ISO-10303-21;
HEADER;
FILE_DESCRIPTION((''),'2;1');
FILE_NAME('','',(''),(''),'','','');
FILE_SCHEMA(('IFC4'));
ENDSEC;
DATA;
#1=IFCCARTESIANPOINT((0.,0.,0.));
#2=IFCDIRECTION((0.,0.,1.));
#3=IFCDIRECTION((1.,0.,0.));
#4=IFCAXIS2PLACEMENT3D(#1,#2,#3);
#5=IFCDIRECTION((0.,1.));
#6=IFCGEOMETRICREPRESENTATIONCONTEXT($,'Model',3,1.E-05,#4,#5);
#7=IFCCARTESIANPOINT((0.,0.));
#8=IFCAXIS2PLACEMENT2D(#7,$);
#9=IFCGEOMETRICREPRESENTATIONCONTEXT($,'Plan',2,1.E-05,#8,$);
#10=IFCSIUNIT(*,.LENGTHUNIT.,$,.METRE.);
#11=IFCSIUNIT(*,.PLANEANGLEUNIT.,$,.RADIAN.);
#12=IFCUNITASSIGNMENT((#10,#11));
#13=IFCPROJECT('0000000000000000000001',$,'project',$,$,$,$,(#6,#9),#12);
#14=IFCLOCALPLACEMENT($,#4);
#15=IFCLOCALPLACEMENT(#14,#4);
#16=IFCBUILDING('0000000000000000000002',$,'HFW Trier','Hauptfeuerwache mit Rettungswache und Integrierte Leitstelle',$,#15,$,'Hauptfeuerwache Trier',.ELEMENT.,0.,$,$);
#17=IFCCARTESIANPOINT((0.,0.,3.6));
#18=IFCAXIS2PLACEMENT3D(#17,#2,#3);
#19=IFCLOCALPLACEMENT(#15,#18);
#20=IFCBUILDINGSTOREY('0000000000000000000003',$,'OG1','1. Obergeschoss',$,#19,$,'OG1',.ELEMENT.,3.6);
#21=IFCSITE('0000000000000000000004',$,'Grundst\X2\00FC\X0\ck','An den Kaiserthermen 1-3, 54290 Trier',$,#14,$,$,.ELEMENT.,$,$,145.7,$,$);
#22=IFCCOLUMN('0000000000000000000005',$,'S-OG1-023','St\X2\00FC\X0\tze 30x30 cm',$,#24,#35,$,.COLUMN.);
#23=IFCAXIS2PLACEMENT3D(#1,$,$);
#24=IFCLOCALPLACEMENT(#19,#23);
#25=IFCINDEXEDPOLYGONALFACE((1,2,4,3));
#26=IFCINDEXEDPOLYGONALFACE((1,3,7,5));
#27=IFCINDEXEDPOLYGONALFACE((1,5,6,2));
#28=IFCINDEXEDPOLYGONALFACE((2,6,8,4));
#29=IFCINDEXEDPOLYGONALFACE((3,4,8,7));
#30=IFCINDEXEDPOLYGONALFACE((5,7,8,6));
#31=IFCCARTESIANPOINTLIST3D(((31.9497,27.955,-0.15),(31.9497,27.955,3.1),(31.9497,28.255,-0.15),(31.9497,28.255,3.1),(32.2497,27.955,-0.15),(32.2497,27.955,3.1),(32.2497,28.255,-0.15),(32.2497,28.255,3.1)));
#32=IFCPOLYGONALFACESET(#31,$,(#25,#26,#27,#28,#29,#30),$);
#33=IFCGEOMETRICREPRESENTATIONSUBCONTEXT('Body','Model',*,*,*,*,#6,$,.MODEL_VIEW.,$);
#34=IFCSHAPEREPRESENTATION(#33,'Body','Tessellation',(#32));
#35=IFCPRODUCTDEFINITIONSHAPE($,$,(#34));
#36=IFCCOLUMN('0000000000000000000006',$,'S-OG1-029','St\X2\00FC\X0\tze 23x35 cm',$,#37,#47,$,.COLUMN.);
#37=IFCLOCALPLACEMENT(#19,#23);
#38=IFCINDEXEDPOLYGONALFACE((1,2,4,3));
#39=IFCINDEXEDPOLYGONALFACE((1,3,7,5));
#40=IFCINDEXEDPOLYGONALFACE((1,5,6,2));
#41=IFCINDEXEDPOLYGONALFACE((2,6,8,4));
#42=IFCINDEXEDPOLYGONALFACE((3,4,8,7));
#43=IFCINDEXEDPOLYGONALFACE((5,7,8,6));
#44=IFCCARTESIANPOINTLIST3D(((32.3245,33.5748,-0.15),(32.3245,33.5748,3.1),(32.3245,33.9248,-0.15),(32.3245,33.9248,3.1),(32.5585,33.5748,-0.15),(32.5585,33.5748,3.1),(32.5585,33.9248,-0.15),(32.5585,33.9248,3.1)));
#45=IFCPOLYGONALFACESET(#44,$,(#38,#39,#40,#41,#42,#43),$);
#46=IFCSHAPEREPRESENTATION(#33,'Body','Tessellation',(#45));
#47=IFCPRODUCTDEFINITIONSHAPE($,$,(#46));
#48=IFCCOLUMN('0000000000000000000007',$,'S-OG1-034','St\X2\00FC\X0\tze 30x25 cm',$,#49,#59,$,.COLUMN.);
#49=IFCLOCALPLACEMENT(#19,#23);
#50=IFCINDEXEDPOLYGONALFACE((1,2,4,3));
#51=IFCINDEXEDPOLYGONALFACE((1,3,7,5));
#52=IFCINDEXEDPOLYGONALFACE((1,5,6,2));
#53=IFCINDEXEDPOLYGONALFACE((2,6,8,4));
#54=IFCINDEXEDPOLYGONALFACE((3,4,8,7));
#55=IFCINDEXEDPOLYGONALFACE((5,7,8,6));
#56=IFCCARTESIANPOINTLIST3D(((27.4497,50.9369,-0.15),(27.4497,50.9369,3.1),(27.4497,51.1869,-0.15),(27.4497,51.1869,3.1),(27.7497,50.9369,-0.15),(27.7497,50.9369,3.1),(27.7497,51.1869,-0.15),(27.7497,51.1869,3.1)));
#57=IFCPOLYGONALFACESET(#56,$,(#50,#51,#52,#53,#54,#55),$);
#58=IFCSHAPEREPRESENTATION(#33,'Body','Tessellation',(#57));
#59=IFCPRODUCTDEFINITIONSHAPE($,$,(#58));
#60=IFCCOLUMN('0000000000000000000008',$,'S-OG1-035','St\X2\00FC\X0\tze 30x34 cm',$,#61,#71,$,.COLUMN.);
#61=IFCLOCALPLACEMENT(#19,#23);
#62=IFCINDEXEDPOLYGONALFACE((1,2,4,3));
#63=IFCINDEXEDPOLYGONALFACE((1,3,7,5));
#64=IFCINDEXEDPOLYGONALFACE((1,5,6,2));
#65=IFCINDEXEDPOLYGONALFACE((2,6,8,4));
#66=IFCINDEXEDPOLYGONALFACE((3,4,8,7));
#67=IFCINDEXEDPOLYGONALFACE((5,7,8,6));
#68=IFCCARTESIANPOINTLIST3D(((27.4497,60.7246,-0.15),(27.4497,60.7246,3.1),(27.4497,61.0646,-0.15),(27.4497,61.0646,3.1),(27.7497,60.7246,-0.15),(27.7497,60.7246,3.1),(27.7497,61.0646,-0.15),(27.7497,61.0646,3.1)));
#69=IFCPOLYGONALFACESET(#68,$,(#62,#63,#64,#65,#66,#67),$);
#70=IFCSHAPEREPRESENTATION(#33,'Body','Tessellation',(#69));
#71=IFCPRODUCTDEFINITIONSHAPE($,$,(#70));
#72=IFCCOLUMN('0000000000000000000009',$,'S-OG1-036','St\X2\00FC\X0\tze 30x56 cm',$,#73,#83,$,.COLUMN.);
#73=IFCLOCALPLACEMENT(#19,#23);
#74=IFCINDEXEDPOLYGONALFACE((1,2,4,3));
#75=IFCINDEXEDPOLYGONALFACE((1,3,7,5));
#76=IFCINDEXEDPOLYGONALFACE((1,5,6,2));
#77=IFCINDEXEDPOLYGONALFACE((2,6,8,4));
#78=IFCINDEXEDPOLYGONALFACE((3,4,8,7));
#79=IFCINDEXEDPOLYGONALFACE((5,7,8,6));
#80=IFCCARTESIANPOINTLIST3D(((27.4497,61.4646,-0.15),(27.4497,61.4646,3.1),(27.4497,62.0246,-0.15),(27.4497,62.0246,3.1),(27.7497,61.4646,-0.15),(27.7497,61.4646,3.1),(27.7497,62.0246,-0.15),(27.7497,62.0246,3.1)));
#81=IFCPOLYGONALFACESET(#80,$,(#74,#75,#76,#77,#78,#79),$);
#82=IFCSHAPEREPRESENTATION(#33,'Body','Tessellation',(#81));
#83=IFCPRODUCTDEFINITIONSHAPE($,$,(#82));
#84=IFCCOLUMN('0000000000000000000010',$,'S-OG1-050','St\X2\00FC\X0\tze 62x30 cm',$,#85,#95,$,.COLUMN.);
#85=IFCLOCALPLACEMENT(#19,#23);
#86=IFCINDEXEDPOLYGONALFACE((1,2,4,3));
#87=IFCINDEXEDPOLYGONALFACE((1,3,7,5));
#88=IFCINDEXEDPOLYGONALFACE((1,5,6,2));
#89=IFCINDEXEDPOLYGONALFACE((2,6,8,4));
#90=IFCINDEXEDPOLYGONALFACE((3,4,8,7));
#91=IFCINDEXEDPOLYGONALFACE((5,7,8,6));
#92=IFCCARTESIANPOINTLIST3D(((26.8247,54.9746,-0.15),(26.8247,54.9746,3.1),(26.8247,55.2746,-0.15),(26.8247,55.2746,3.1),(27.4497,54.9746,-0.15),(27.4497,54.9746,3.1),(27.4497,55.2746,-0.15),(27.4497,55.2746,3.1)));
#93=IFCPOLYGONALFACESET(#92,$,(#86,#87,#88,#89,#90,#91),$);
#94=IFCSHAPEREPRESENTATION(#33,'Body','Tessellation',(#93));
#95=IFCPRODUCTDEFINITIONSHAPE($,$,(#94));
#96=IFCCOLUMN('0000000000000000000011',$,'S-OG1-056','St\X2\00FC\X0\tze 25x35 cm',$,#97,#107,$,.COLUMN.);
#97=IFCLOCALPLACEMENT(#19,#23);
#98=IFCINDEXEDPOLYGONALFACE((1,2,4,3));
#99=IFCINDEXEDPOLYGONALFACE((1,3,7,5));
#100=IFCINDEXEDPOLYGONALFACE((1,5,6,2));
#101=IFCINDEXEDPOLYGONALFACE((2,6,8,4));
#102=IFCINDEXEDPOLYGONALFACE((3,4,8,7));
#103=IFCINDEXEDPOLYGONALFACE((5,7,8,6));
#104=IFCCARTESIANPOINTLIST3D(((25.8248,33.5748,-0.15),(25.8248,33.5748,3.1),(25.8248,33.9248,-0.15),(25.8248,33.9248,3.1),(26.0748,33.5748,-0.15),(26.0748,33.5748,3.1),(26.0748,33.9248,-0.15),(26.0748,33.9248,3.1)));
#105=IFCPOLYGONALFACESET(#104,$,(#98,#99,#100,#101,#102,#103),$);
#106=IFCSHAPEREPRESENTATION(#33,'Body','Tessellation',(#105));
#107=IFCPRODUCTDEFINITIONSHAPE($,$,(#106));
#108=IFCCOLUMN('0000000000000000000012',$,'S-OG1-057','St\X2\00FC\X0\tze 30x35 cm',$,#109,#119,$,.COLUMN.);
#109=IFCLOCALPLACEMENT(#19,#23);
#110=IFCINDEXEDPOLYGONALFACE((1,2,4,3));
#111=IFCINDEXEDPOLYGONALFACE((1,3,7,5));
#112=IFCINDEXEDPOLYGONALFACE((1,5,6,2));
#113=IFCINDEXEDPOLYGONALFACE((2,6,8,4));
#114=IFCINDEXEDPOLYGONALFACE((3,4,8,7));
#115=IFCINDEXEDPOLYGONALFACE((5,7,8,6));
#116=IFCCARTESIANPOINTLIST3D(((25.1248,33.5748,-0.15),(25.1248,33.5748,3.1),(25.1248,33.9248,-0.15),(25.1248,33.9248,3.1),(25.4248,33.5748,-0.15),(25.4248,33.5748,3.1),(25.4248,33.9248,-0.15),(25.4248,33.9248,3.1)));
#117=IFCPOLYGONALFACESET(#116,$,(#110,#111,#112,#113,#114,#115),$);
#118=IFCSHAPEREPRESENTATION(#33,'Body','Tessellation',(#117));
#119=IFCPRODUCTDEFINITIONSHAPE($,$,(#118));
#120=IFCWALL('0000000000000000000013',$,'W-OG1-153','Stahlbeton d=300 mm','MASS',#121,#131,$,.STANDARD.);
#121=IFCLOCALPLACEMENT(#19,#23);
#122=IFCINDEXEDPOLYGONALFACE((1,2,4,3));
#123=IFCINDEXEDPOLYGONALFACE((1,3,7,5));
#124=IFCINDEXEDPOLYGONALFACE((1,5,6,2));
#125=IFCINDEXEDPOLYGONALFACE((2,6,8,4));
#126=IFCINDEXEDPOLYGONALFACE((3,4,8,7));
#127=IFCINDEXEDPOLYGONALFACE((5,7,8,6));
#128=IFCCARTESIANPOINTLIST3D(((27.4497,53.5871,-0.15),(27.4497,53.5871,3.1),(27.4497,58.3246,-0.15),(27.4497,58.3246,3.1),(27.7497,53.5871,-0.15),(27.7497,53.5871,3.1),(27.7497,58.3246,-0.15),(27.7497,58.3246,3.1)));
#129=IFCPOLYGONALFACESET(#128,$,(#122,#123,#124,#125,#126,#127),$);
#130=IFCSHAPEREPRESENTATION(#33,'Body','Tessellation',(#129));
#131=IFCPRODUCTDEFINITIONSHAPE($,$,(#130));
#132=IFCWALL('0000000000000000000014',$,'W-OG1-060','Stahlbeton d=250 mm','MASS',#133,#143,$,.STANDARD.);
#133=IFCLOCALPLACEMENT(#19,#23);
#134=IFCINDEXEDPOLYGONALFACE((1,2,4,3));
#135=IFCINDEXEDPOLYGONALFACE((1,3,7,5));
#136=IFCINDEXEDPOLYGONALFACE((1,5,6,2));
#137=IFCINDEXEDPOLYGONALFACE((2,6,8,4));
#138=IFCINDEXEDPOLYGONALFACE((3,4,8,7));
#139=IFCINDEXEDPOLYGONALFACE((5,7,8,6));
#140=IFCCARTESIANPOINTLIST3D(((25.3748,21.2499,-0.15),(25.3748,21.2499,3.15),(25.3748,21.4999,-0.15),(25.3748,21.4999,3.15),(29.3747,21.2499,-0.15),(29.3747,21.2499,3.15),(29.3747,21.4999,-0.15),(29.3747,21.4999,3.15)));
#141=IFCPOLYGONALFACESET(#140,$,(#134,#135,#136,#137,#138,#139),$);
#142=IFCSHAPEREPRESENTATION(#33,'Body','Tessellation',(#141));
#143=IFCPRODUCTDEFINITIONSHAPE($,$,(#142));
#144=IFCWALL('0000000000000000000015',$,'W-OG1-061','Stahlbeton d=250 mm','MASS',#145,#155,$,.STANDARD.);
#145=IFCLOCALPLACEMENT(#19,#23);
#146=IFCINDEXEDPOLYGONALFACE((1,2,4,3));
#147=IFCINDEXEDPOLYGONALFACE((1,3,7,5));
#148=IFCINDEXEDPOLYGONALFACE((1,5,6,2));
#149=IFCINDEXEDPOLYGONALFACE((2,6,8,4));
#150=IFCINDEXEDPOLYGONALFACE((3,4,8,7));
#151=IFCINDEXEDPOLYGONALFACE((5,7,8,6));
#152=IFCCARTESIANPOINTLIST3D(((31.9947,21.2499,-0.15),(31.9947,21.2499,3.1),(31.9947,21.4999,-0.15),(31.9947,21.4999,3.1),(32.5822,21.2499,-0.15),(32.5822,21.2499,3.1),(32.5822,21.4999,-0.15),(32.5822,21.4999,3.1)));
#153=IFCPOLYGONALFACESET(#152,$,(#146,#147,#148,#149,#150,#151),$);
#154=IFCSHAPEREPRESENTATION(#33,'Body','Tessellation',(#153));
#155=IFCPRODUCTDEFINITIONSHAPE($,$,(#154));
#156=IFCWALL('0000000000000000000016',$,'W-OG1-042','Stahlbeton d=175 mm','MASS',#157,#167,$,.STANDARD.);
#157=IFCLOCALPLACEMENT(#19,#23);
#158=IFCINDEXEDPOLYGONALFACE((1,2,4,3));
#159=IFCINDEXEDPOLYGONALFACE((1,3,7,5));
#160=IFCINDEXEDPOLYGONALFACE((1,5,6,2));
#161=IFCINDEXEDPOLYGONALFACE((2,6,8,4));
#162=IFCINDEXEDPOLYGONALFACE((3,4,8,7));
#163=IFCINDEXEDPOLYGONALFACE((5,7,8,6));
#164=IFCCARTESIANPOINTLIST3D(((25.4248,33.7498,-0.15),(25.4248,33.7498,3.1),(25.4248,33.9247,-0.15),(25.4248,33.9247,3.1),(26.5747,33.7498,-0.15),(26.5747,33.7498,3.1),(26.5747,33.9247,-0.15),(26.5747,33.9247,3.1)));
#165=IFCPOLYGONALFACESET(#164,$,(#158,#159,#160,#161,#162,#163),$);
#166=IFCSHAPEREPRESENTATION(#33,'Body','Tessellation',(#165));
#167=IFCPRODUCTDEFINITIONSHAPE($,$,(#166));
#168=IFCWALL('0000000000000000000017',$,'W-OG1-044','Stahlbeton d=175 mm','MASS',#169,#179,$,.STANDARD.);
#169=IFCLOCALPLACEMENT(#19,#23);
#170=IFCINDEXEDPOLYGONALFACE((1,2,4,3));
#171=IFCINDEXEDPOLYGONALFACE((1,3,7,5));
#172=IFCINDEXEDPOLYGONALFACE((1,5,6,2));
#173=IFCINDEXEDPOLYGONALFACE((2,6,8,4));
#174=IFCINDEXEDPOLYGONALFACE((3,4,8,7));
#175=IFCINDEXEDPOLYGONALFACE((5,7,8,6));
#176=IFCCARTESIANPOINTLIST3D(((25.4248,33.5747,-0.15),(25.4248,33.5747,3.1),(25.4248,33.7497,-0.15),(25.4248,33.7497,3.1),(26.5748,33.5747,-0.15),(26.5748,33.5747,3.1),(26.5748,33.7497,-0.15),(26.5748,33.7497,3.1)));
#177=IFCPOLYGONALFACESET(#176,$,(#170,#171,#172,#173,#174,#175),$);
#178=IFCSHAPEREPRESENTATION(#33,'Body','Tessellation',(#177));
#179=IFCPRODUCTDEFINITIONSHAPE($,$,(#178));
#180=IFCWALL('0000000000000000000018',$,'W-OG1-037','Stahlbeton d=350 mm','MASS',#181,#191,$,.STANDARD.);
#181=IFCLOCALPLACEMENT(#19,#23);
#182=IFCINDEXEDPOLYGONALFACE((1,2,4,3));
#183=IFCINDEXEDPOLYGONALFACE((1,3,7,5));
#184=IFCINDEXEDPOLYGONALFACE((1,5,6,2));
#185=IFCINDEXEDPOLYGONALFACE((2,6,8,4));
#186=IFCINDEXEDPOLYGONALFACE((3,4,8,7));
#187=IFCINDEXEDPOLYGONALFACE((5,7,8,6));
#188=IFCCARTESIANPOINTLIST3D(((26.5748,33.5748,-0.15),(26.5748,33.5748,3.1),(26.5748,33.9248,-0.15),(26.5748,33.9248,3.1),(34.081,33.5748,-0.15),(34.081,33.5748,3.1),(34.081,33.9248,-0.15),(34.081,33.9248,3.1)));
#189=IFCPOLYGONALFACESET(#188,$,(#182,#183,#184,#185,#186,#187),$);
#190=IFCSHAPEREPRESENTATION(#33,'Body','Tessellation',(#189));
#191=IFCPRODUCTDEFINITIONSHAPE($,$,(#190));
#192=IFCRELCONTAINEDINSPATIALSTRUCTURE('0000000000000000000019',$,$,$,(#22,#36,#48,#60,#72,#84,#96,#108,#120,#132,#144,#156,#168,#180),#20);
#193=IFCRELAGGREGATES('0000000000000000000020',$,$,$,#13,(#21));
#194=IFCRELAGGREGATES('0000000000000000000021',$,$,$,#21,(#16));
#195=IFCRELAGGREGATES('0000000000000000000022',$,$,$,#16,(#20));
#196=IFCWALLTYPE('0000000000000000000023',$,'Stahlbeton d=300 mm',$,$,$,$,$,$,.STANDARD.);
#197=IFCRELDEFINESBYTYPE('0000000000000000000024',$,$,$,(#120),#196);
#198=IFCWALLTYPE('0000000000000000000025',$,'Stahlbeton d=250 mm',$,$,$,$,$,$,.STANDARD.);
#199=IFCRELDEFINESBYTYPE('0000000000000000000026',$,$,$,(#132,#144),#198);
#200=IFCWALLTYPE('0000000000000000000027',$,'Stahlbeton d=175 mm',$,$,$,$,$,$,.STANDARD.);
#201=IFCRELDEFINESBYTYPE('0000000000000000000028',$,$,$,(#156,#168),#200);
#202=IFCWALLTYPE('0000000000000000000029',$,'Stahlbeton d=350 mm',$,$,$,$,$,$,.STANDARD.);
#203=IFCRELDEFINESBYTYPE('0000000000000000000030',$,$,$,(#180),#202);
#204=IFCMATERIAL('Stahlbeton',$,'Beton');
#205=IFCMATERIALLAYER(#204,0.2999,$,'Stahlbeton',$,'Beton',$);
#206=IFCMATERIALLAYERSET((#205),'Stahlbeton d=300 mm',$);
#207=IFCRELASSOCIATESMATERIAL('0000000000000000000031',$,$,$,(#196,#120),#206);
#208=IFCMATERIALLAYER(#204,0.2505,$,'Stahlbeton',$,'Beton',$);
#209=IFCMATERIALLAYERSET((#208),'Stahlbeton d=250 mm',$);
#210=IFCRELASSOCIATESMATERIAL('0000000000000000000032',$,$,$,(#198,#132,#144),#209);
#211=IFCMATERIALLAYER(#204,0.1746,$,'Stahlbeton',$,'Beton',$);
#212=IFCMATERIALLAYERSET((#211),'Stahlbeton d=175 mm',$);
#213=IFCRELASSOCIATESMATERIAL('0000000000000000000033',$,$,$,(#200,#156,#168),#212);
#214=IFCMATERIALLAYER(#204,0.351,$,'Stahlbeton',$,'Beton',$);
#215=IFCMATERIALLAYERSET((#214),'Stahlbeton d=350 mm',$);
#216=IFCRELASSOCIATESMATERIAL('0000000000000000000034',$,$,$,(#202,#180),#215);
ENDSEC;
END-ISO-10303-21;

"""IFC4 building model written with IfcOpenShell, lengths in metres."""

from ifc_helpers import new_model, si_unit, direction, frame, frame_2d, origin_with_axes, origin_2d, place, context, subcontext, project, spatial, rectangle, extrude, material, layer, layer_set, layer_usage, type_object, element, save


model = new_model("IFC4")

# Units and contexts
model_context = context("Model", 3, precision=1e-05, world=origin_with_axes(), true_north=direction((0.0, 1.0)))
plan_context = context("Plan", 2, precision=1e-05, world=origin_2d())
body_context = subcontext(model_context, "Body", "Model", "MODEL_VIEW")
ifc_project = project(units=[si_unit("LENGTHUNIT", "METRE"), si_unit("PLANEANGLEUNIT", "RADIAN")], contexts=[model_context, plan_context])

# Site, building, storey
site_placement = place(None, origin_with_axes())
site = spatial("IfcSite", under=ifc_project, at=site_placement, Name="Grundstück", Description="An den Kaiserthermen 1-3, 54290 Trier", CompositionType="ELEMENT", RefElevation=145.7)
building_placement = place(site_placement, origin_with_axes())
building = spatial("IfcBuilding", under=site, at=building_placement, Name="HFW Trier", Description="Hauptfeuerwache mit Rettungswache und Integrierte Leitstelle", LongName="Hauptfeuerwache Trier", CompositionType="ELEMENT", ElevationOfRefHeight=0.0)
storey_placement = place(building_placement, frame((0.0, 0.0, 3.6), z_axis=(0.0, 0.0, 1.0), x_axis=(1.0, 0.0, 0.0)))
storey = spatial("IfcBuildingStorey", under=building, at=storey_placement, Name="OG1", Description="1. Obergeschoss", LongName="OG1", CompositionType="ELEMENT", Elevation=3.6)

# Columns
column_1_placement = place(storey_placement, frame((31.9497, 28.105, -0.15), z_axis=(0.0, 0.0, 1.0), x_axis=(1.0, 0.0, 0.0)))
element("IfcColumn", 1, at=column_1_placement, inside=storey, Name="S-OG1-023", Description="Stütze 30x30 cm", PredefinedType="COLUMN", context=body_context, shape_type="SweptSolid", body=[
    extrude(rectangle(XDim=0.3, YDim=0.3, at=frame_2d((0.15, 0.0))), origin_with_axes(), (0.0, 0.0, 1.0), 3.25),
])
column_2_placement = place(storey_placement, frame((32.3245, 33.7498, -0.15), z_axis=(0.0, 0.0, 1.0), x_axis=(1.0, 0.0, 0.0)))
element("IfcColumn", 2, at=column_2_placement, inside=storey, Name="S-OG1-029", Description="Stütze 23x35 cm", PredefinedType="COLUMN", context=body_context, shape_type="SweptSolid", body=[
    extrude(rectangle(XDim=0.234, YDim=0.35, at=frame_2d((0.117, 0.0))), origin_with_axes(), (0.0, 0.0, 1.0), 3.25),
])
column_3_placement = place(storey_placement, frame((27.4497, 51.0619, -0.15), z_axis=(0.0, 0.0, 1.0), x_axis=(1.0, 0.0, 0.0)))
element("IfcColumn", 3, at=column_3_placement, inside=storey, Name="S-OG1-034", Description="Stütze 30x25 cm", PredefinedType="COLUMN", context=body_context, shape_type="SweptSolid", body=[
    extrude(rectangle(XDim=0.3, YDim=0.25, at=frame_2d((0.15, 0.0))), origin_with_axes(), (0.0, 0.0, 1.0), 3.25),
])
column_4_placement = place(storey_placement, frame((27.4497, 60.8946, -0.15), z_axis=(0.0, 0.0, 1.0), x_axis=(1.0, 0.0, 0.0)))
element("IfcColumn", 4, at=column_4_placement, inside=storey, Name="S-OG1-035", Description="Stütze 30x34 cm", PredefinedType="COLUMN", context=body_context, shape_type="SweptSolid", body=[
    extrude(rectangle(XDim=0.3, YDim=0.34, at=frame_2d((0.15, 0.0))), origin_with_axes(), (0.0, 0.0, 1.0), 3.25),
])
column_5_placement = place(storey_placement, frame((27.4497, 61.7446, -0.15), z_axis=(0.0, 0.0, 1.0), x_axis=(1.0, 0.0, 0.0)))
element("IfcColumn", 5, at=column_5_placement, inside=storey, Name="S-OG1-036", Description="Stütze 30x56 cm", PredefinedType="COLUMN", context=body_context, shape_type="SweptSolid", body=[
    extrude(rectangle(XDim=0.3, YDim=0.56, at=frame_2d((0.15, 0.0))), origin_with_axes(), (0.0, 0.0, 1.0), 3.25),
])
column_6_placement = place(storey_placement, frame((26.8247, 55.1246, -0.15), z_axis=(0.0, 0.0, 1.0), x_axis=(1.0, 0.0, 0.0)))
element("IfcColumn", 6, at=column_6_placement, inside=storey, Name="S-OG1-050", Description="Stütze 62x30 cm", PredefinedType="COLUMN", context=body_context, shape_type="SweptSolid", body=[
    extrude(rectangle(XDim=0.625, YDim=0.3, at=frame_2d((0.3125, 0.0))), origin_with_axes(), (0.0, 0.0, 1.0), 3.25),
])
column_7_placement = place(storey_placement, frame((25.8248, 33.7498, -0.15), z_axis=(0.0, 0.0, 1.0), x_axis=(1.0, 0.0, 0.0)))
element("IfcColumn", 7, at=column_7_placement, inside=storey, Name="S-OG1-056", Description="Stütze 25x35 cm", PredefinedType="COLUMN", context=body_context, shape_type="SweptSolid", body=[
    extrude(rectangle(XDim=0.25, YDim=0.35, at=frame_2d((0.125, 0.0))), origin_with_axes(), (0.0, 0.0, 1.0), 3.25),
])
column_8_placement = place(storey_placement, frame((25.1248, 33.7498, -0.15), z_axis=(0.0, 0.0, 1.0), x_axis=(1.0, 0.0, 0.0)))
element("IfcColumn", 8, at=column_8_placement, inside=storey, Name="S-OG1-057", Description="Stütze 30x35 cm", PredefinedType="COLUMN", context=body_context, shape_type="SweptSolid", body=[
    extrude(rectangle(XDim=0.3, YDim=0.35, at=frame_2d((0.15, 0.0))), origin_with_axes(), (0.0, 0.0, 1.0), 3.25),
])

# Walls
ifc_material_1 = material(Name="Stahlbeton", Category="Beton")
ifc_layer_1 = layer(ifc_material_1, 0.2999, Name="Stahlbeton", Category="Beton")
ifc_layer_set_1 = layer_set([ifc_layer_1], Name="Stahlbeton d=300 mm")
ifc_layer_usage_1 = layer_usage(ifc_layer_set_1, "AXIS2", "POSITIVE", -0.15)
wall_type_1 = type_object("IfcWallType", Name="Stahlbeton d=300 mm", PredefinedType="STANDARD", material=ifc_layer_set_1)
wall_1_placement = place(storey_placement, frame((27.5997, 58.3246, -0.15), z_axis=(0.0, 0.0, 1.0), x_axis=(0.0, -1.0, 0.0)))
element("IfcWall", 9, at=wall_1_placement, inside=storey, type_object=wall_type_1, material=ifc_layer_usage_1, Name="W-OG1-153", Description="Stahlbeton d=300 mm", ObjectType="MASS", PredefinedType="STANDARD", context=body_context, shape_type="SweptSolid", body=[
    extrude(rectangle(XDim=4.7375, YDim=0.3, at=frame_2d((2.3687, 0.0))), origin_with_axes(), (0.0, 0.0, 1.0), 3.25),
])
ifc_layer_2 = layer(ifc_material_1, 0.2505, Name="Stahlbeton", Category="Beton")
ifc_layer_set_2 = layer_set([ifc_layer_2], Name="Stahlbeton d=250 mm")
ifc_layer_usage_2 = layer_usage(ifc_layer_set_2, "AXIS2", "POSITIVE", -0.125)
wall_type_2 = type_object("IfcWallType", Name="Stahlbeton d=250 mm", PredefinedType="STANDARD", material=ifc_layer_set_2)
wall_2_placement = place(storey_placement, frame((25.3748, 21.3749, -0.15), z_axis=(0.0, 0.0, 1.0), x_axis=(1.0, 0.0, 0.0)))
element("IfcWall", 10, at=wall_2_placement, inside=storey, type_object=wall_type_2, material=ifc_layer_usage_2, Name="W-OG1-060", Description="Stahlbeton d=250 mm", ObjectType="MASS", PredefinedType="STANDARD", context=body_context, shape_type="SweptSolid", body=[
    extrude(rectangle(XDim=3.9999, YDim=0.25, at=frame_2d((2.0, 0.0))), origin_with_axes(), (0.0, 0.0, 1.0), 3.3),
])
ifc_layer_usage_3 = layer_usage(ifc_layer_set_2, "AXIS2", "POSITIVE", -0.125)
wall_3_placement = place(storey_placement, frame((31.9947, 21.3749, -0.15), z_axis=(0.0, 0.0, 1.0), x_axis=(1.0, 0.0, 0.0)))
element("IfcWall", 11, at=wall_3_placement, inside=storey, type_object=wall_type_2, material=ifc_layer_usage_3, Name="W-OG1-061", Description="Stahlbeton d=250 mm", ObjectType="MASS", PredefinedType="STANDARD", context=body_context, shape_type="SweptSolid", body=[
    extrude(rectangle(XDim=0.5875, YDim=0.25, at=frame_2d((0.2937, 0.0))), origin_with_axes(), (0.0, 0.0, 1.0), 3.25),
])
ifc_layer_3 = layer(ifc_material_1, 0.1746, Name="Stahlbeton", Category="Beton")
ifc_layer_set_3 = layer_set([ifc_layer_3], Name="Stahlbeton d=175 mm")
ifc_layer_usage_4 = layer_usage(ifc_layer_set_3, "AXIS2", "POSITIVE", -0.0874)
wall_type_3 = type_object("IfcWallType", Name="Stahlbeton d=175 mm", PredefinedType="STANDARD", material=ifc_layer_set_3)
wall_4_placement = place(storey_placement, frame((25.4248, 33.8373, -0.15), z_axis=(0.0, 0.0, 1.0), x_axis=(1.0, 0.0, 0.0)))
element("IfcWall", 12, at=wall_4_placement, inside=storey, type_object=wall_type_3, material=ifc_layer_usage_4, Name="W-OG1-042", Description="Stahlbeton d=175 mm", ObjectType="MASS", PredefinedType="STANDARD", context=body_context, shape_type="SweptSolid", body=[
    extrude(rectangle(XDim=1.1499, YDim=0.1749, at=frame_2d((0.5749, 0.0))), origin_with_axes(), (0.0, 0.0, 1.0), 3.25),
])
ifc_layer_usage_5 = layer_usage(ifc_layer_set_3, "AXIS2", "POSITIVE", -0.0875)
wall_5_placement = place(storey_placement, frame((25.4248, 33.6622, -0.15), z_axis=(0.0, 0.0, 1.0), x_axis=(1.0, 0.0, 0.0)))
element("IfcWall", 13, at=wall_5_placement, inside=storey, type_object=wall_type_3, material=ifc_layer_usage_5, Name="W-OG1-044", Description="Stahlbeton d=175 mm", ObjectType="MASS", PredefinedType="STANDARD", context=body_context, shape_type="SweptSolid", body=[
    extrude(rectangle(XDim=1.15, YDim=0.175, at=frame_2d((0.575, 0.0))), origin_with_axes(), (0.0, 0.0, 1.0), 3.25),
])
ifc_layer_4 = layer(ifc_material_1, 0.351, Name="Stahlbeton", Category="Beton")
ifc_layer_set_4 = layer_set([ifc_layer_4], Name="Stahlbeton d=350 mm")
ifc_layer_usage_6 = layer_usage(ifc_layer_set_4, "AXIS2", "POSITIVE", -0.175)
wall_type_4 = type_object("IfcWallType", Name="Stahlbeton d=350 mm", PredefinedType="STANDARD", material=ifc_layer_set_4)
wall_6_placement = place(storey_placement, frame((26.5748, 33.7498, -0.15), z_axis=(0.0, 0.0, 1.0), x_axis=(1.0, 0.0, 0.0)))
element("IfcWall", 14, at=wall_6_placement, inside=storey, type_object=wall_type_4, material=ifc_layer_usage_6, Name="W-OG1-037", Description="Stahlbeton d=350 mm", ObjectType="MASS", PredefinedType="STANDARD", context=body_context, shape_type="SweptSolid", body=[
    extrude(rectangle(XDim=7.5062, YDim=0.35, at=frame_2d((3.7531, 0.0))), origin_with_axes(), (0.0, 0.0, 1.0), 3.25),
])

save(model, "model.ifc")
